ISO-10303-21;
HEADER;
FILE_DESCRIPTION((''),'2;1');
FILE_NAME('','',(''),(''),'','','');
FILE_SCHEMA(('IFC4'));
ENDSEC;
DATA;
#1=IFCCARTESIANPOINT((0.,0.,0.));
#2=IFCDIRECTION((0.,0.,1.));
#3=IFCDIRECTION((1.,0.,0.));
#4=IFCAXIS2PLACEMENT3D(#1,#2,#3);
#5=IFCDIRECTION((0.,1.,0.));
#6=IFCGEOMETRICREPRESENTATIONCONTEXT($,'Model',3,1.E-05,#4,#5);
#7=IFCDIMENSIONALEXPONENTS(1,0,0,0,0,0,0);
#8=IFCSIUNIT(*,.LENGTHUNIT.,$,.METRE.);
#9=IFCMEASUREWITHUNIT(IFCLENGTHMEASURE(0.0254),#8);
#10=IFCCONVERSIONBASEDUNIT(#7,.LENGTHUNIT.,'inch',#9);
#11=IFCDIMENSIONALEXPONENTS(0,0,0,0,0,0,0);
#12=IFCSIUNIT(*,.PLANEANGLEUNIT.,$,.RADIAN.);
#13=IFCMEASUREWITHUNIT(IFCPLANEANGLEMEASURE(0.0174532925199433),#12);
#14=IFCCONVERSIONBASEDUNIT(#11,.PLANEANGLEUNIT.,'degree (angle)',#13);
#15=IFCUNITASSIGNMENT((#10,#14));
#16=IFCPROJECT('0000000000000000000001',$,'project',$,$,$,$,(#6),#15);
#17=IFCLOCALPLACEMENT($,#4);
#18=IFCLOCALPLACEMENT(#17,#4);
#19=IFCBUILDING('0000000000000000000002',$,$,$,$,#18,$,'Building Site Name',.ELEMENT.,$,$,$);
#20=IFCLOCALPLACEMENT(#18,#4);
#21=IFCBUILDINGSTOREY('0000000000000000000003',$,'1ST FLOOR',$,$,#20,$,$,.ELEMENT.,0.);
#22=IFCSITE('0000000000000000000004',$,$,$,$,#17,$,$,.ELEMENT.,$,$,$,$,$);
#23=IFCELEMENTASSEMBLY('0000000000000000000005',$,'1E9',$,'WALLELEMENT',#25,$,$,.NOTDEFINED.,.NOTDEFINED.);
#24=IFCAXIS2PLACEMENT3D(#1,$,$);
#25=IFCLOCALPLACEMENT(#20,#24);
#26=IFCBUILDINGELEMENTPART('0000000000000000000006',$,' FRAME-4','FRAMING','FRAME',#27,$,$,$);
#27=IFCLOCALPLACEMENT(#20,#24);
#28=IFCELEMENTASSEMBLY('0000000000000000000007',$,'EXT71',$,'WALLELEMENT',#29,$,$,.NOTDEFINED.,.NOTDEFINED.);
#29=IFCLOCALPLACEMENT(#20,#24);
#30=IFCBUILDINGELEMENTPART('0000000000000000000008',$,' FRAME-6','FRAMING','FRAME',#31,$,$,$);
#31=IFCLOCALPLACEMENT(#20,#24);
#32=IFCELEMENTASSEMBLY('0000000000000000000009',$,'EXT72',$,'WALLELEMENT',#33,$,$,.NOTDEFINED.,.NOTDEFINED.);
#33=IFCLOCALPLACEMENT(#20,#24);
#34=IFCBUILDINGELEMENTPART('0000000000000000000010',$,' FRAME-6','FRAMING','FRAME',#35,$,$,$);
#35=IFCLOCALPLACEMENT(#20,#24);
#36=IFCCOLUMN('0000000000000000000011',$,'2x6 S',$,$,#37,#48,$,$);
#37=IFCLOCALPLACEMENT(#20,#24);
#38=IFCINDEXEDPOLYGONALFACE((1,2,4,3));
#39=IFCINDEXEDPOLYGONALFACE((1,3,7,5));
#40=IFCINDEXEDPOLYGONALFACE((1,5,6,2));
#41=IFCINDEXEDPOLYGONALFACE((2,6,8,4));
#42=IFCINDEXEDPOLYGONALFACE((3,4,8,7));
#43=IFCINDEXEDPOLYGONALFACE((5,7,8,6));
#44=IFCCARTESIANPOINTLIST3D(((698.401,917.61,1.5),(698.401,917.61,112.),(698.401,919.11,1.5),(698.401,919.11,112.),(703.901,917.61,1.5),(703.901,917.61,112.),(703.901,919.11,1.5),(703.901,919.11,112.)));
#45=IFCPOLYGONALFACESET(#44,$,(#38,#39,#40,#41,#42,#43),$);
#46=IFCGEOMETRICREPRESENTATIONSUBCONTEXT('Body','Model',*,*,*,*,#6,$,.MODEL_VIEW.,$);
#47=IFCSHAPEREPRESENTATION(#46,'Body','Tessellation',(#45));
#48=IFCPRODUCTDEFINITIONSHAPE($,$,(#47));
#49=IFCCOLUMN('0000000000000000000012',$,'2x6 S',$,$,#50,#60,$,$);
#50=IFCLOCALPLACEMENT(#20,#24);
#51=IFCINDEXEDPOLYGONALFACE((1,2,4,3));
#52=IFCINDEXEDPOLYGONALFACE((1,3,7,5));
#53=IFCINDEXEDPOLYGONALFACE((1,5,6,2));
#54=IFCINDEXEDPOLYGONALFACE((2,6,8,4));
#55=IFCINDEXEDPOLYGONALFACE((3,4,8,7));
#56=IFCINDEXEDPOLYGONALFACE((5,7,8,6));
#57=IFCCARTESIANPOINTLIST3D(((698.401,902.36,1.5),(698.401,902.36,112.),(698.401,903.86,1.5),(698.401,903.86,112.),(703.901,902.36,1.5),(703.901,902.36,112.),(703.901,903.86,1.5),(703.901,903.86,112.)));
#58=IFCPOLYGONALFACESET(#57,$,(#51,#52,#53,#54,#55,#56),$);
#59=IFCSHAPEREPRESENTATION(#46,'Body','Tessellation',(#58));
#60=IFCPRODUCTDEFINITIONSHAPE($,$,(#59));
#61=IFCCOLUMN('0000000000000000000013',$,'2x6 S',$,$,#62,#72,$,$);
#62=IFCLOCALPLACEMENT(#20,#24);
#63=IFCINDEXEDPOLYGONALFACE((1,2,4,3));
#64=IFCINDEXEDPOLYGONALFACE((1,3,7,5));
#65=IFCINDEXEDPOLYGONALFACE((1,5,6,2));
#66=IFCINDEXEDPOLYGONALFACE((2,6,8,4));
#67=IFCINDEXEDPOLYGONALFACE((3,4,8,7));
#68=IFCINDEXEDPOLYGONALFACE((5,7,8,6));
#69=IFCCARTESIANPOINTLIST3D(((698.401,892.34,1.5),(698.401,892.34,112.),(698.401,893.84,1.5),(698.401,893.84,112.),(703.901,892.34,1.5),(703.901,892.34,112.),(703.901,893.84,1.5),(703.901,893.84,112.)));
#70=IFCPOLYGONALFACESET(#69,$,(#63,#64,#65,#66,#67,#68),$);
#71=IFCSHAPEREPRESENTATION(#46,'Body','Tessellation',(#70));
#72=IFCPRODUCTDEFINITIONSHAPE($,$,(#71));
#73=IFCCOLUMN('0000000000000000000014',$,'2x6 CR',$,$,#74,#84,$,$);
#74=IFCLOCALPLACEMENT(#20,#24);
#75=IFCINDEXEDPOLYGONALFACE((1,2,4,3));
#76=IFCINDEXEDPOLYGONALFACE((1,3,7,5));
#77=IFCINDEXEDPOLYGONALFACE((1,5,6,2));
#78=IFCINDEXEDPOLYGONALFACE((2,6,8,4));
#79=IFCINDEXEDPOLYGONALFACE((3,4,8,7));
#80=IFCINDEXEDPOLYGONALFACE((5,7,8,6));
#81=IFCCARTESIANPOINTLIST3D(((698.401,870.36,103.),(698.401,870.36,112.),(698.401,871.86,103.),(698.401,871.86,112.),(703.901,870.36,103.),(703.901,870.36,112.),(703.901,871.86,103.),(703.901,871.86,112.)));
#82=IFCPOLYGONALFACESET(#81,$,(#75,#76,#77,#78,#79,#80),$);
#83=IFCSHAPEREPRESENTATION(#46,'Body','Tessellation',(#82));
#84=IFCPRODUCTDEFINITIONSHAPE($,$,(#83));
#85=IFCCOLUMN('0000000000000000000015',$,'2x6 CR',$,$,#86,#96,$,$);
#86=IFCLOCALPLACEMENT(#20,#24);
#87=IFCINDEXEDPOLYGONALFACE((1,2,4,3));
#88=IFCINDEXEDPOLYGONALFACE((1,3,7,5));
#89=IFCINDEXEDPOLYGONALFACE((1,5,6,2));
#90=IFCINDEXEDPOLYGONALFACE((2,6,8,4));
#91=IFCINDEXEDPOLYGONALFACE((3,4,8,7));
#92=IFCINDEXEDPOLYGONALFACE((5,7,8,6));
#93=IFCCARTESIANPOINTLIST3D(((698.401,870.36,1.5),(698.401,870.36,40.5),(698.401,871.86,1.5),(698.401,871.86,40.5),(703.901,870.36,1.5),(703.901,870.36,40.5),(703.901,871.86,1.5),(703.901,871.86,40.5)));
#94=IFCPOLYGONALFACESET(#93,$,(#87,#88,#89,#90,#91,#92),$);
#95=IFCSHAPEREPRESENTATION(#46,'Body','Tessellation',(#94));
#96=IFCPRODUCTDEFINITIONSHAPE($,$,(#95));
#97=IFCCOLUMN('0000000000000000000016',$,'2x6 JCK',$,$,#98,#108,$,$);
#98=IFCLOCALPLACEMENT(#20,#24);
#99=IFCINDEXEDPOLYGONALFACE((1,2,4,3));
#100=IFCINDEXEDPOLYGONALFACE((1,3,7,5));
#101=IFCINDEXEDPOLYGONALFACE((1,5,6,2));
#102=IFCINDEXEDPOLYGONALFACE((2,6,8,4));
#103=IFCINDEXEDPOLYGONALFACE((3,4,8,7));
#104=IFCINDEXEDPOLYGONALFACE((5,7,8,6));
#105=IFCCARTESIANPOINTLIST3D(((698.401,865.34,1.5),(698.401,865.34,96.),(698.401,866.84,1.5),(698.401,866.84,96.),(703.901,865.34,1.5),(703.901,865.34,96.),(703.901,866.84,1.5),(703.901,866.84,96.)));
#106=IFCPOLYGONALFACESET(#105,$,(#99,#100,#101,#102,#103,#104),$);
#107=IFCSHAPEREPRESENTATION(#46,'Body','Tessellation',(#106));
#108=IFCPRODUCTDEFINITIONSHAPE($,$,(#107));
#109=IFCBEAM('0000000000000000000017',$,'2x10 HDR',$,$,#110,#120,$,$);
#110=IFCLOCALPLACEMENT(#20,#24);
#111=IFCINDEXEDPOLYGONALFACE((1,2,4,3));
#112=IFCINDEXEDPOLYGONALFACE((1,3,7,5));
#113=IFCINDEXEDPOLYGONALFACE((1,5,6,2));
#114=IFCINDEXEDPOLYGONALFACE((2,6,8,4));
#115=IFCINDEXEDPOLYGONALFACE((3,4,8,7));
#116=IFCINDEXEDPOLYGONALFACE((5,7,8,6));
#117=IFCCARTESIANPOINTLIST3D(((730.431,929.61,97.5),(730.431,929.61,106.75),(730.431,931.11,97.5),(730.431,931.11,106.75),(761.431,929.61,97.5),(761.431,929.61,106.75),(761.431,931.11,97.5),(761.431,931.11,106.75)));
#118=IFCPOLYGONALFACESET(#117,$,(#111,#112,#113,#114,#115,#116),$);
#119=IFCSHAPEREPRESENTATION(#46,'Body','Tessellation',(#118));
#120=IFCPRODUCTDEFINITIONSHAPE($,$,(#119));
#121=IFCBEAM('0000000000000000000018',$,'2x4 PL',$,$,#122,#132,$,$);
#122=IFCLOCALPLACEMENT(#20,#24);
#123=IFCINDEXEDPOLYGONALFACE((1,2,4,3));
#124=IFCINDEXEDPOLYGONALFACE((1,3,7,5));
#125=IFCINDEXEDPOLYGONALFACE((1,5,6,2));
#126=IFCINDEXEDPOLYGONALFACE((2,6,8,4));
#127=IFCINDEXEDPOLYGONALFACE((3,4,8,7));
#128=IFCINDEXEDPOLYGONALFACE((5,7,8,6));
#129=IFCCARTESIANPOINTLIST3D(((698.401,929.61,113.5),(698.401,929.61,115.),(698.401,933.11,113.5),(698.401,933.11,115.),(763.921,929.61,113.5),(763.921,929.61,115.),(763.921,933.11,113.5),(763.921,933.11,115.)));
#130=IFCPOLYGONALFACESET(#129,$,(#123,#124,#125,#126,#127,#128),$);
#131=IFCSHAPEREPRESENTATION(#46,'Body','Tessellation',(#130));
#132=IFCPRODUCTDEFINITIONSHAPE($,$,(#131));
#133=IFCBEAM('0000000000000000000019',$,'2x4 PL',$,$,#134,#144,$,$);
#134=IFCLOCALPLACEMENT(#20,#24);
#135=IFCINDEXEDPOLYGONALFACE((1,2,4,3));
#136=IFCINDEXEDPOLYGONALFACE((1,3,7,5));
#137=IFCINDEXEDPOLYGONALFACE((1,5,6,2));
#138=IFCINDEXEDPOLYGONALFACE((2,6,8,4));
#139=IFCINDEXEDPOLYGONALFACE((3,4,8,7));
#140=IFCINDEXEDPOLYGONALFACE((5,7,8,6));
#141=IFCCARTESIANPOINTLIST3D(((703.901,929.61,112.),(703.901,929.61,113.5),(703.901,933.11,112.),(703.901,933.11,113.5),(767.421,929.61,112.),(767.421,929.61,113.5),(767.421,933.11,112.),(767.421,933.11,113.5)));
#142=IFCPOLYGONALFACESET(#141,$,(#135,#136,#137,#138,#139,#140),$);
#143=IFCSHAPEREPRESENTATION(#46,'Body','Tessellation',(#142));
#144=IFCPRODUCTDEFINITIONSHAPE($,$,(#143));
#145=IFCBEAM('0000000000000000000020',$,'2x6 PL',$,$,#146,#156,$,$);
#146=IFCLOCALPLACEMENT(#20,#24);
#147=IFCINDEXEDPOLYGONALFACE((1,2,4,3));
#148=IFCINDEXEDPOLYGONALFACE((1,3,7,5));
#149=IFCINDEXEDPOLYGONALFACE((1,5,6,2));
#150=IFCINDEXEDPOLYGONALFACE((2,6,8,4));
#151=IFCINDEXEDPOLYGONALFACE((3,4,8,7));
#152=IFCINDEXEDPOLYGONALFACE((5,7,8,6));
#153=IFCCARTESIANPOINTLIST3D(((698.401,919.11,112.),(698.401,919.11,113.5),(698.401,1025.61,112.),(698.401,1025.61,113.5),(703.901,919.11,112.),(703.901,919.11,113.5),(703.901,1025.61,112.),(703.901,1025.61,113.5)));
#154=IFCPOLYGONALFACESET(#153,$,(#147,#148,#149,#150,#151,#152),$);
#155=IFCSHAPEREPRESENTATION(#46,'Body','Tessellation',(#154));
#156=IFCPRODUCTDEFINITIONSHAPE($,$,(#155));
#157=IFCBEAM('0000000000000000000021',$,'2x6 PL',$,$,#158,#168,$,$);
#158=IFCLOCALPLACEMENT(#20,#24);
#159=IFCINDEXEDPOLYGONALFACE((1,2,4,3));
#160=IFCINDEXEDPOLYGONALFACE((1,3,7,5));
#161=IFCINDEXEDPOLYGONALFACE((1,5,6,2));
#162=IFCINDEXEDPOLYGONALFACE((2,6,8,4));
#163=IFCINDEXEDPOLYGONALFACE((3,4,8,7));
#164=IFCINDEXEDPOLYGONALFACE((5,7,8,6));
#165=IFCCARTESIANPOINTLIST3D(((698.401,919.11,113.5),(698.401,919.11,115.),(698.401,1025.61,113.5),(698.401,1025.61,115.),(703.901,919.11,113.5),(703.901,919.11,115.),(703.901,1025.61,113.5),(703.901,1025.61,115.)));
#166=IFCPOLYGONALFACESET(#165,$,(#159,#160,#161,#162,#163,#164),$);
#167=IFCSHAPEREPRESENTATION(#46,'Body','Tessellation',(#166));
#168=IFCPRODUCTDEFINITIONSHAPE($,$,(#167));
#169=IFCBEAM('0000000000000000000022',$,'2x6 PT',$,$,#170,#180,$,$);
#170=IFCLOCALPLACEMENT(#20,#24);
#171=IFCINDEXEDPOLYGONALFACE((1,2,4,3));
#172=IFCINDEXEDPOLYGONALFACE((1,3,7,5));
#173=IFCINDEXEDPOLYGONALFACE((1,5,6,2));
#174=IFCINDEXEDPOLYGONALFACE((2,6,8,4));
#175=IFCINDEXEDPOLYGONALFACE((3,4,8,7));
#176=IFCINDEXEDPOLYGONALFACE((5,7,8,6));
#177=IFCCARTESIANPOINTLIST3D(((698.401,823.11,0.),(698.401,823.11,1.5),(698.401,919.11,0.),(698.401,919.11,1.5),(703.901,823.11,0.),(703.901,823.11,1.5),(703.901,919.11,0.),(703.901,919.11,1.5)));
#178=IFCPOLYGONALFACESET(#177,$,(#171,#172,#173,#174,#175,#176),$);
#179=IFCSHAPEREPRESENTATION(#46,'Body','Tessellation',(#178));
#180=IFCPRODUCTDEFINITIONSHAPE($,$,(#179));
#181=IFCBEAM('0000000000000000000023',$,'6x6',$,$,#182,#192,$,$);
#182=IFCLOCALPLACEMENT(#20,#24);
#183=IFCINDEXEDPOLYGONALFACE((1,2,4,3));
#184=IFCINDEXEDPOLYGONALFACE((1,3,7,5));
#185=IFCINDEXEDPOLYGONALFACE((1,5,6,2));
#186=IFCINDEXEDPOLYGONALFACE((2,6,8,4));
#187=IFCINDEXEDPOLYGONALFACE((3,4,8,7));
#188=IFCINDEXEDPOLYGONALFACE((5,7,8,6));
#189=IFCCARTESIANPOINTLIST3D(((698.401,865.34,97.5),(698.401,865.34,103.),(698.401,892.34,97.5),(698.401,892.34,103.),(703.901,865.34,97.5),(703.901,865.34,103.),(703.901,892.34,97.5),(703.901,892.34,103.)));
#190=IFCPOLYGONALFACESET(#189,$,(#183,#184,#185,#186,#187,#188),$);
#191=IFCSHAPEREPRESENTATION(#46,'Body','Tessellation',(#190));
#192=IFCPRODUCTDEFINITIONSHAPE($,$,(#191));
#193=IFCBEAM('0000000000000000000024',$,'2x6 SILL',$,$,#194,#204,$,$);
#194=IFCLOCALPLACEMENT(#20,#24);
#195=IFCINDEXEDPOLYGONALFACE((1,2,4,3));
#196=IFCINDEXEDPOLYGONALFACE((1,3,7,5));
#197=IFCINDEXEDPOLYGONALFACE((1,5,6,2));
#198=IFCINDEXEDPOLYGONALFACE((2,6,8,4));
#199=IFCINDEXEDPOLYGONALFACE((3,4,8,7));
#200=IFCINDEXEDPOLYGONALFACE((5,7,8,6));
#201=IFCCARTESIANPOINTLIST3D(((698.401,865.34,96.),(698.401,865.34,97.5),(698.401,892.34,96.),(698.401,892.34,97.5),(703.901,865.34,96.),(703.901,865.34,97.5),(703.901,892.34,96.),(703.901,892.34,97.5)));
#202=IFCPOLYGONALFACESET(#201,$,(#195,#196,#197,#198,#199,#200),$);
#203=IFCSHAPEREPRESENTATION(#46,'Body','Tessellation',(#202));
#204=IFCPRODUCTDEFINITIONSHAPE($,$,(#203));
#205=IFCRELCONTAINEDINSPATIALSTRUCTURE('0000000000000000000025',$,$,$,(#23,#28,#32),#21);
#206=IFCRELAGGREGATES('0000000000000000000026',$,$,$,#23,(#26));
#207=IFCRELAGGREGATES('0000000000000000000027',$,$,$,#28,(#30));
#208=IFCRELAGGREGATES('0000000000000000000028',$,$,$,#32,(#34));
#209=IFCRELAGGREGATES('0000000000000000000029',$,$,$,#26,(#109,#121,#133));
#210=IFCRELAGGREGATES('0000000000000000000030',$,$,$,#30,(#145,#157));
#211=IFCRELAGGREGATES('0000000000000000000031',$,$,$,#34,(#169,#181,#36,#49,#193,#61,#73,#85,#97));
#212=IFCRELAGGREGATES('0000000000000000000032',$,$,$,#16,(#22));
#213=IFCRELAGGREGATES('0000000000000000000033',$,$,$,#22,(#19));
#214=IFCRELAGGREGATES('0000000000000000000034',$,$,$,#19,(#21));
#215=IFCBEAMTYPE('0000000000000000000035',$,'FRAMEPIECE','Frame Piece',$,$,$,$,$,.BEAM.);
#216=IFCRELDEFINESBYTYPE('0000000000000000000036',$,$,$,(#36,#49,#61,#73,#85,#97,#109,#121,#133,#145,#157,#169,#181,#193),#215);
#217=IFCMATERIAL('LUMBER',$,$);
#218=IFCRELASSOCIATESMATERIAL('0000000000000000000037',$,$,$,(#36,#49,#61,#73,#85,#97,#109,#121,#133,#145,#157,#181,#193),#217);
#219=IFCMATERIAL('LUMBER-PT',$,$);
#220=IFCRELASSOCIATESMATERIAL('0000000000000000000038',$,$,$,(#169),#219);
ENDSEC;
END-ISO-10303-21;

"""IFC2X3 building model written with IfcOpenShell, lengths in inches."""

from ifc_helpers import new_model, entity, si_unit, converted_unit, direction, frame, frame_2d, origin_with_axes, place, context, subcontext, project, spatial, rectangle, extrude, material, type_object, element, aggregate, save


model = new_model("IFC2X3")

# Units and contexts
model_context = context("Model", 3, precision=1e-05, world=origin_with_axes(), true_north=direction((0.0, 1.0, 0.0)))
body_context = subcontext(model_context, "Body", "Model", "MODEL_VIEW")
ifc_project = project(units=[converted_unit("LENGTHUNIT", "inch", entity("IfcLengthMeasure", 0.0254), si_unit("LENGTHUNIT", "METRE"), dimensions=[1, 0, 0, 0, 0, 0, 0]), converted_unit("PLANEANGLEUNIT", "degree (angle)", entity("IfcPlaneAngleMeasure", 0.0174532925199433), si_unit("PLANEANGLEUNIT", "RADIAN"), dimensions=[0, 0, 0, 0, 0, 0, 0])], contexts=[model_context])

# Site, building, storey
site_placement = place(None, origin_with_axes())
site = spatial("IfcSite", under=ifc_project, at=site_placement, CompositionType="ELEMENT")
building_placement = place(site_placement, origin_with_axes())
building = spatial("IfcBuilding", under=site, at=building_placement, LongName="Building Site Name", CompositionType="ELEMENT")
storey_placement = place(building_placement, origin_with_axes())
storey = spatial("IfcBuildingStorey", under=building, at=storey_placement, Name="1ST FLOOR", CompositionType="ELEMENT", Elevation=0.0)

# Element assemblies, building element parts, columns
assembly_1_placement = place(storey_placement, origin_with_axes())
assembly_1 = element("IfcElementAssembly", 1, at=assembly_1_placement, inside=storey, Name="1E9", ObjectType="WALLELEMENT", AssemblyPlace="NOTDEFINED", PredefinedType="NOTDEFINED")
building_element_part_1 = element("IfcBuildingElementPart", 2, Name=" FRAME-4", Description="FRAMING", ObjectType="FRAME")
aggregate(assembly_1, [building_element_part_1])
ifc_material_1 = material(Name="LUMBER")
beam_type = type_object("IfcBeamType", Name="FRAMEPIECE", Description="Frame Piece", PredefinedType="BEAM")
assembly_2_placement = place(storey_placement, origin_with_axes())
assembly_2 = element("IfcElementAssembly", 3, at=assembly_2_placement, inside=storey, Name="EXT71", ObjectType="WALLELEMENT", AssemblyPlace="NOTDEFINED", PredefinedType="NOTDEFINED")
building_element_part_2 = element("IfcBuildingElementPart", 4, Name=" FRAME-6", Description="FRAMING", ObjectType="FRAME")
aggregate(assembly_2, [building_element_part_2])
assembly_3_placement = place(storey_placement, origin_with_axes())
assembly_3 = element("IfcElementAssembly", 5, at=assembly_3_placement, inside=storey, Name="EXT72", ObjectType="WALLELEMENT", AssemblyPlace="NOTDEFINED", PredefinedType="NOTDEFINED")
building_element_part_3 = element("IfcBuildingElementPart", 6, Name=" FRAME-6", Description="FRAMING", ObjectType="FRAME")
aggregate(assembly_3, [building_element_part_3])
column_1_placement = place(assembly_3_placement, frame((701.151, 918.36, 112.0), z_axis=(0.0, 0.0, -1.0), x_axis=(0.0, -1.0, 0.0)))
column_1 = element("IfcColumn", 7, at=column_1_placement, type_object=beam_type, material=ifc_material_1, Name="2x6 S", context=body_context, shape_type="SweptSolid", body=[
    extrude(rectangle(XDim=1.5, YDim=5.5, at=frame_2d((0.0, 0.0), x_axis=(-1.0, 0.0))), origin_with_axes(), (0.0, 0.0, 1.0), 110.5),
])
column_2_placement = place(assembly_3_placement, frame((701.151, 903.11, 112.0), z_axis=(0.0, 0.0, -1.0), x_axis=(0.0, -1.0, 0.0)))
column_2 = element("IfcColumn", 8, at=column_2_placement, type_object=beam_type, material=ifc_material_1, Name="2x6 S", context=body_context, shape_type="SweptSolid", body=[
    extrude(rectangle(XDim=1.5, YDim=5.5, at=frame_2d((0.0, 0.0), x_axis=(-1.0, 0.0))), origin_with_axes(), (0.0, 0.0, 1.0), 110.5),
])
column_3_placement = place(assembly_3_placement, frame((701.151, 893.09, 112.0), z_axis=(0.0, 0.0, -1.0), x_axis=(0.0, -1.0, 0.0)))
column_3 = element("IfcColumn", 9, at=column_3_placement, type_object=beam_type, material=ifc_material_1, Name="2x6 S", context=body_context, shape_type="SweptSolid", body=[
    extrude(rectangle(XDim=1.5, YDim=5.5, at=frame_2d((0.0, 0.0), x_axis=(-1.0, 0.0))), origin_with_axes(), (0.0, 0.0, 1.0), 110.5),
])
column_4_placement = place(assembly_3_placement, frame((701.151, 871.11, 112.0), z_axis=(0.0, 0.0, -1.0), x_axis=(0.0, -1.0, 0.0)))
column_4 = element("IfcColumn", 10, at=column_4_placement, type_object=beam_type, material=ifc_material_1, Name="2x6 CR", context=body_context, shape_type="SweptSolid", body=[
    extrude(rectangle(XDim=1.5, YDim=5.5, at=frame_2d((0.0, 0.0), x_axis=(-1.0, 0.0))), origin_with_axes(), (0.0, 0.0, 1.0), 9.0),
])
column_5_placement = place(assembly_3_placement, frame((701.151, 871.11, 40.5), z_axis=(0.0, 0.0, -1.0), x_axis=(0.0, -1.0, 0.0)))
column_5 = element("IfcColumn", 11, at=column_5_placement, type_object=beam_type, material=ifc_material_1, Name="2x6 CR", context=body_context, shape_type="SweptSolid", body=[
    extrude(rectangle(XDim=1.5, YDim=5.5, at=frame_2d((0.0, 0.0), x_axis=(-1.0, 0.0))), origin_with_axes(), (0.0, 0.0, 1.0), 39.0),
])
column_6_placement = place(assembly_3_placement, frame((701.151, 866.09, 1.5), z_axis=(0.0, 0.0, 1.0), x_axis=(0.0, 1.0, 0.0)))
column_6 = element("IfcColumn", 12, at=column_6_placement, type_object=beam_type, material=ifc_material_1, Name="2x6 JCK", context=body_context, shape_type="SweptSolid", body=[
    extrude(rectangle(XDim=1.5, YDim=5.5, at=frame_2d((0.0, 0.0), x_axis=(-1.0, 0.0))), frame((0.0, 0.0, 0.0), z_axis=(0.0, 0.0, 1.0), x_axis=(1.0, 0.0, 0.0)), (0.0, 0.0, 1.0), 94.5),
])

# Beams
beam_1_placement = place(assembly_1_placement, frame((761.431, 930.36, 102.125), z_axis=(-1.0, 0.0, 0.0), x_axis=(0.0, -1.0, 0.0)))
beam_1 = element("IfcBeam", 13, at=beam_1_placement, type_object=beam_type, material=ifc_material_1, Name="2x10 HDR", context=body_context, shape_type="SweptSolid", body=[
    extrude(rectangle(XDim=1.5, YDim=9.25, at=frame_2d((0.0, 0.0), x_axis=(-1.0, 0.0))), origin_with_axes(), (0.0, 0.0, 1.0), 31.0),
])
beam_2_placement = place(assembly_1_placement, frame((698.401, 931.36, 114.25), z_axis=(1.0, 0.0, 0.0), x_axis=(0.0, 0.0, -1.0)))
beam_2 = element("IfcBeam", 14, at=beam_2_placement, type_object=beam_type, material=ifc_material_1, Name="2x4 PL", context=body_context, shape_type="SweptSolid", body=[
    extrude(rectangle(XDim=1.5, YDim=3.5, at=frame_2d((0.0, 0.0), x_axis=(-1.0, 0.0))), origin_with_axes(), (0.0, 0.0, 1.0), 65.52),
])
beam_3_placement = place(assembly_1_placement, frame((703.901, 931.36, 112.75), z_axis=(1.0, 0.0, 0.0), x_axis=(0.0, 0.0, -1.0)))
beam_3 = element("IfcBeam", 15, at=beam_3_placement, type_object=beam_type, material=ifc_material_1, Name="2x4 PL", context=body_context, shape_type="SweptSolid", body=[
    extrude(rectangle(XDim=1.5, YDim=3.5, at=frame_2d((0.0, 0.0), x_axis=(-1.0, 0.0))), frame((0.0, 0.0, 0.0), z_axis=(0.0, 0.0, 1.0), x_axis=(1.0, 0.0, 0.0)), (0.0, 0.0, 1.0), 63.52),
])
aggregate(building_element_part_1, [beam_1, beam_2, beam_3])
beam_4_placement = place(assembly_2_placement, frame((701.151, 919.11, 112.75), z_axis=(0.0, 1.0, 0.0), x_axis=(0.0, 0.0, -1.0)))
beam_4 = element("IfcBeam", 16, at=beam_4_placement, type_object=beam_type, material=ifc_material_1, Name="2x6 PL", context=body_context, shape_type="SweptSolid", body=[
    extrude(rectangle(XDim=1.5, YDim=5.5, at=frame_2d((0.0, 0.0), x_axis=(-1.0, 0.0))), origin_with_axes(), (0.0, 0.0, 1.0), 106.5),
])
beam_5_placement = place(assembly_2_placement, frame((701.151, 919.11, 114.25), z_axis=(0.0, 1.0, 0.0), x_axis=(0.0, 0.0, -1.0)))
beam_5 = element("IfcBeam", 17, at=beam_5_placement, type_object=beam_type, material=ifc_material_1, Name="2x6 PL", context=body_context, shape_type="SweptSolid", body=[
    extrude(rectangle(XDim=1.5, YDim=5.5, at=frame_2d((0.0, 0.0), x_axis=(-1.0, 0.0))), origin_with_axes(), (0.0, 0.0, 1.0), 106.5),
])
aggregate(building_element_part_2, [beam_4, beam_5])
ifc_material_2 = material(Name="LUMBER-PT")
beam_6_placement = place(assembly_3_placement, frame((701.151, 919.11, 0.75), z_axis=(0.0, -1.0, 0.0), x_axis=(0.0, 0.0, 1.0)))
beam_6 = element("IfcBeam", 18, at=beam_6_placement, type_object=beam_type, material=ifc_material_2, Name="2x6 PT", context=body_context, shape_type="SweptSolid", body=[
    extrude(rectangle(XDim=1.5, YDim=5.5, at=frame_2d((0.0, 0.0), x_axis=(-1.0, 0.0))), origin_with_axes(), (0.0, 0.0, 1.0), 96.0),
])
beam_7_placement = place(assembly_3_placement, frame((701.151, 892.34, 100.25), z_axis=(0.0, -1.0, 0.0), x_axis=(1.0, 0.0, 0.0)))
beam_7 = element("IfcBeam", 19, at=beam_7_placement, type_object=beam_type, material=ifc_material_1, Name="6x6", context=body_context, shape_type="SweptSolid", body=[
    extrude(rectangle(XDim=5.5, YDim=5.5, at=frame_2d((0.0, 0.0), x_axis=(-1.0, 0.0))), frame((0.0, 0.0, 0.0), z_axis=(0.0, 0.0, 1.0), x_axis=(1.0, 0.0, 0.0)), (0.0, 0.0, 1.0), 27.0),
])
beam_8_placement = place(assembly_3_placement, frame((701.151, 892.34, 96.75), z_axis=(0.0, -1.0, 0.0), x_axis=(0.0, 0.0, 1.0)))
beam_8 = element("IfcBeam", 20, at=beam_8_placement, type_object=beam_type, material=ifc_material_1, Name="2x6 SILL", context=body_context, shape_type="SweptSolid", body=[
    extrude(rectangle(XDim=1.5, YDim=5.5, at=frame_2d((0.0, 0.0), x_axis=(-1.0, 0.0))), frame((0.0, 0.0, 0.0), z_axis=(0.0, 0.0, 1.0), x_axis=(1.0, 0.0, 0.0)), (0.0, 0.0, 1.0), 27.0),
])
aggregate(building_element_part_3, [beam_6, beam_7, column_1, column_2, beam_8, column_3, column_4, column_5, column_6])

save(model, "model.ifc")
